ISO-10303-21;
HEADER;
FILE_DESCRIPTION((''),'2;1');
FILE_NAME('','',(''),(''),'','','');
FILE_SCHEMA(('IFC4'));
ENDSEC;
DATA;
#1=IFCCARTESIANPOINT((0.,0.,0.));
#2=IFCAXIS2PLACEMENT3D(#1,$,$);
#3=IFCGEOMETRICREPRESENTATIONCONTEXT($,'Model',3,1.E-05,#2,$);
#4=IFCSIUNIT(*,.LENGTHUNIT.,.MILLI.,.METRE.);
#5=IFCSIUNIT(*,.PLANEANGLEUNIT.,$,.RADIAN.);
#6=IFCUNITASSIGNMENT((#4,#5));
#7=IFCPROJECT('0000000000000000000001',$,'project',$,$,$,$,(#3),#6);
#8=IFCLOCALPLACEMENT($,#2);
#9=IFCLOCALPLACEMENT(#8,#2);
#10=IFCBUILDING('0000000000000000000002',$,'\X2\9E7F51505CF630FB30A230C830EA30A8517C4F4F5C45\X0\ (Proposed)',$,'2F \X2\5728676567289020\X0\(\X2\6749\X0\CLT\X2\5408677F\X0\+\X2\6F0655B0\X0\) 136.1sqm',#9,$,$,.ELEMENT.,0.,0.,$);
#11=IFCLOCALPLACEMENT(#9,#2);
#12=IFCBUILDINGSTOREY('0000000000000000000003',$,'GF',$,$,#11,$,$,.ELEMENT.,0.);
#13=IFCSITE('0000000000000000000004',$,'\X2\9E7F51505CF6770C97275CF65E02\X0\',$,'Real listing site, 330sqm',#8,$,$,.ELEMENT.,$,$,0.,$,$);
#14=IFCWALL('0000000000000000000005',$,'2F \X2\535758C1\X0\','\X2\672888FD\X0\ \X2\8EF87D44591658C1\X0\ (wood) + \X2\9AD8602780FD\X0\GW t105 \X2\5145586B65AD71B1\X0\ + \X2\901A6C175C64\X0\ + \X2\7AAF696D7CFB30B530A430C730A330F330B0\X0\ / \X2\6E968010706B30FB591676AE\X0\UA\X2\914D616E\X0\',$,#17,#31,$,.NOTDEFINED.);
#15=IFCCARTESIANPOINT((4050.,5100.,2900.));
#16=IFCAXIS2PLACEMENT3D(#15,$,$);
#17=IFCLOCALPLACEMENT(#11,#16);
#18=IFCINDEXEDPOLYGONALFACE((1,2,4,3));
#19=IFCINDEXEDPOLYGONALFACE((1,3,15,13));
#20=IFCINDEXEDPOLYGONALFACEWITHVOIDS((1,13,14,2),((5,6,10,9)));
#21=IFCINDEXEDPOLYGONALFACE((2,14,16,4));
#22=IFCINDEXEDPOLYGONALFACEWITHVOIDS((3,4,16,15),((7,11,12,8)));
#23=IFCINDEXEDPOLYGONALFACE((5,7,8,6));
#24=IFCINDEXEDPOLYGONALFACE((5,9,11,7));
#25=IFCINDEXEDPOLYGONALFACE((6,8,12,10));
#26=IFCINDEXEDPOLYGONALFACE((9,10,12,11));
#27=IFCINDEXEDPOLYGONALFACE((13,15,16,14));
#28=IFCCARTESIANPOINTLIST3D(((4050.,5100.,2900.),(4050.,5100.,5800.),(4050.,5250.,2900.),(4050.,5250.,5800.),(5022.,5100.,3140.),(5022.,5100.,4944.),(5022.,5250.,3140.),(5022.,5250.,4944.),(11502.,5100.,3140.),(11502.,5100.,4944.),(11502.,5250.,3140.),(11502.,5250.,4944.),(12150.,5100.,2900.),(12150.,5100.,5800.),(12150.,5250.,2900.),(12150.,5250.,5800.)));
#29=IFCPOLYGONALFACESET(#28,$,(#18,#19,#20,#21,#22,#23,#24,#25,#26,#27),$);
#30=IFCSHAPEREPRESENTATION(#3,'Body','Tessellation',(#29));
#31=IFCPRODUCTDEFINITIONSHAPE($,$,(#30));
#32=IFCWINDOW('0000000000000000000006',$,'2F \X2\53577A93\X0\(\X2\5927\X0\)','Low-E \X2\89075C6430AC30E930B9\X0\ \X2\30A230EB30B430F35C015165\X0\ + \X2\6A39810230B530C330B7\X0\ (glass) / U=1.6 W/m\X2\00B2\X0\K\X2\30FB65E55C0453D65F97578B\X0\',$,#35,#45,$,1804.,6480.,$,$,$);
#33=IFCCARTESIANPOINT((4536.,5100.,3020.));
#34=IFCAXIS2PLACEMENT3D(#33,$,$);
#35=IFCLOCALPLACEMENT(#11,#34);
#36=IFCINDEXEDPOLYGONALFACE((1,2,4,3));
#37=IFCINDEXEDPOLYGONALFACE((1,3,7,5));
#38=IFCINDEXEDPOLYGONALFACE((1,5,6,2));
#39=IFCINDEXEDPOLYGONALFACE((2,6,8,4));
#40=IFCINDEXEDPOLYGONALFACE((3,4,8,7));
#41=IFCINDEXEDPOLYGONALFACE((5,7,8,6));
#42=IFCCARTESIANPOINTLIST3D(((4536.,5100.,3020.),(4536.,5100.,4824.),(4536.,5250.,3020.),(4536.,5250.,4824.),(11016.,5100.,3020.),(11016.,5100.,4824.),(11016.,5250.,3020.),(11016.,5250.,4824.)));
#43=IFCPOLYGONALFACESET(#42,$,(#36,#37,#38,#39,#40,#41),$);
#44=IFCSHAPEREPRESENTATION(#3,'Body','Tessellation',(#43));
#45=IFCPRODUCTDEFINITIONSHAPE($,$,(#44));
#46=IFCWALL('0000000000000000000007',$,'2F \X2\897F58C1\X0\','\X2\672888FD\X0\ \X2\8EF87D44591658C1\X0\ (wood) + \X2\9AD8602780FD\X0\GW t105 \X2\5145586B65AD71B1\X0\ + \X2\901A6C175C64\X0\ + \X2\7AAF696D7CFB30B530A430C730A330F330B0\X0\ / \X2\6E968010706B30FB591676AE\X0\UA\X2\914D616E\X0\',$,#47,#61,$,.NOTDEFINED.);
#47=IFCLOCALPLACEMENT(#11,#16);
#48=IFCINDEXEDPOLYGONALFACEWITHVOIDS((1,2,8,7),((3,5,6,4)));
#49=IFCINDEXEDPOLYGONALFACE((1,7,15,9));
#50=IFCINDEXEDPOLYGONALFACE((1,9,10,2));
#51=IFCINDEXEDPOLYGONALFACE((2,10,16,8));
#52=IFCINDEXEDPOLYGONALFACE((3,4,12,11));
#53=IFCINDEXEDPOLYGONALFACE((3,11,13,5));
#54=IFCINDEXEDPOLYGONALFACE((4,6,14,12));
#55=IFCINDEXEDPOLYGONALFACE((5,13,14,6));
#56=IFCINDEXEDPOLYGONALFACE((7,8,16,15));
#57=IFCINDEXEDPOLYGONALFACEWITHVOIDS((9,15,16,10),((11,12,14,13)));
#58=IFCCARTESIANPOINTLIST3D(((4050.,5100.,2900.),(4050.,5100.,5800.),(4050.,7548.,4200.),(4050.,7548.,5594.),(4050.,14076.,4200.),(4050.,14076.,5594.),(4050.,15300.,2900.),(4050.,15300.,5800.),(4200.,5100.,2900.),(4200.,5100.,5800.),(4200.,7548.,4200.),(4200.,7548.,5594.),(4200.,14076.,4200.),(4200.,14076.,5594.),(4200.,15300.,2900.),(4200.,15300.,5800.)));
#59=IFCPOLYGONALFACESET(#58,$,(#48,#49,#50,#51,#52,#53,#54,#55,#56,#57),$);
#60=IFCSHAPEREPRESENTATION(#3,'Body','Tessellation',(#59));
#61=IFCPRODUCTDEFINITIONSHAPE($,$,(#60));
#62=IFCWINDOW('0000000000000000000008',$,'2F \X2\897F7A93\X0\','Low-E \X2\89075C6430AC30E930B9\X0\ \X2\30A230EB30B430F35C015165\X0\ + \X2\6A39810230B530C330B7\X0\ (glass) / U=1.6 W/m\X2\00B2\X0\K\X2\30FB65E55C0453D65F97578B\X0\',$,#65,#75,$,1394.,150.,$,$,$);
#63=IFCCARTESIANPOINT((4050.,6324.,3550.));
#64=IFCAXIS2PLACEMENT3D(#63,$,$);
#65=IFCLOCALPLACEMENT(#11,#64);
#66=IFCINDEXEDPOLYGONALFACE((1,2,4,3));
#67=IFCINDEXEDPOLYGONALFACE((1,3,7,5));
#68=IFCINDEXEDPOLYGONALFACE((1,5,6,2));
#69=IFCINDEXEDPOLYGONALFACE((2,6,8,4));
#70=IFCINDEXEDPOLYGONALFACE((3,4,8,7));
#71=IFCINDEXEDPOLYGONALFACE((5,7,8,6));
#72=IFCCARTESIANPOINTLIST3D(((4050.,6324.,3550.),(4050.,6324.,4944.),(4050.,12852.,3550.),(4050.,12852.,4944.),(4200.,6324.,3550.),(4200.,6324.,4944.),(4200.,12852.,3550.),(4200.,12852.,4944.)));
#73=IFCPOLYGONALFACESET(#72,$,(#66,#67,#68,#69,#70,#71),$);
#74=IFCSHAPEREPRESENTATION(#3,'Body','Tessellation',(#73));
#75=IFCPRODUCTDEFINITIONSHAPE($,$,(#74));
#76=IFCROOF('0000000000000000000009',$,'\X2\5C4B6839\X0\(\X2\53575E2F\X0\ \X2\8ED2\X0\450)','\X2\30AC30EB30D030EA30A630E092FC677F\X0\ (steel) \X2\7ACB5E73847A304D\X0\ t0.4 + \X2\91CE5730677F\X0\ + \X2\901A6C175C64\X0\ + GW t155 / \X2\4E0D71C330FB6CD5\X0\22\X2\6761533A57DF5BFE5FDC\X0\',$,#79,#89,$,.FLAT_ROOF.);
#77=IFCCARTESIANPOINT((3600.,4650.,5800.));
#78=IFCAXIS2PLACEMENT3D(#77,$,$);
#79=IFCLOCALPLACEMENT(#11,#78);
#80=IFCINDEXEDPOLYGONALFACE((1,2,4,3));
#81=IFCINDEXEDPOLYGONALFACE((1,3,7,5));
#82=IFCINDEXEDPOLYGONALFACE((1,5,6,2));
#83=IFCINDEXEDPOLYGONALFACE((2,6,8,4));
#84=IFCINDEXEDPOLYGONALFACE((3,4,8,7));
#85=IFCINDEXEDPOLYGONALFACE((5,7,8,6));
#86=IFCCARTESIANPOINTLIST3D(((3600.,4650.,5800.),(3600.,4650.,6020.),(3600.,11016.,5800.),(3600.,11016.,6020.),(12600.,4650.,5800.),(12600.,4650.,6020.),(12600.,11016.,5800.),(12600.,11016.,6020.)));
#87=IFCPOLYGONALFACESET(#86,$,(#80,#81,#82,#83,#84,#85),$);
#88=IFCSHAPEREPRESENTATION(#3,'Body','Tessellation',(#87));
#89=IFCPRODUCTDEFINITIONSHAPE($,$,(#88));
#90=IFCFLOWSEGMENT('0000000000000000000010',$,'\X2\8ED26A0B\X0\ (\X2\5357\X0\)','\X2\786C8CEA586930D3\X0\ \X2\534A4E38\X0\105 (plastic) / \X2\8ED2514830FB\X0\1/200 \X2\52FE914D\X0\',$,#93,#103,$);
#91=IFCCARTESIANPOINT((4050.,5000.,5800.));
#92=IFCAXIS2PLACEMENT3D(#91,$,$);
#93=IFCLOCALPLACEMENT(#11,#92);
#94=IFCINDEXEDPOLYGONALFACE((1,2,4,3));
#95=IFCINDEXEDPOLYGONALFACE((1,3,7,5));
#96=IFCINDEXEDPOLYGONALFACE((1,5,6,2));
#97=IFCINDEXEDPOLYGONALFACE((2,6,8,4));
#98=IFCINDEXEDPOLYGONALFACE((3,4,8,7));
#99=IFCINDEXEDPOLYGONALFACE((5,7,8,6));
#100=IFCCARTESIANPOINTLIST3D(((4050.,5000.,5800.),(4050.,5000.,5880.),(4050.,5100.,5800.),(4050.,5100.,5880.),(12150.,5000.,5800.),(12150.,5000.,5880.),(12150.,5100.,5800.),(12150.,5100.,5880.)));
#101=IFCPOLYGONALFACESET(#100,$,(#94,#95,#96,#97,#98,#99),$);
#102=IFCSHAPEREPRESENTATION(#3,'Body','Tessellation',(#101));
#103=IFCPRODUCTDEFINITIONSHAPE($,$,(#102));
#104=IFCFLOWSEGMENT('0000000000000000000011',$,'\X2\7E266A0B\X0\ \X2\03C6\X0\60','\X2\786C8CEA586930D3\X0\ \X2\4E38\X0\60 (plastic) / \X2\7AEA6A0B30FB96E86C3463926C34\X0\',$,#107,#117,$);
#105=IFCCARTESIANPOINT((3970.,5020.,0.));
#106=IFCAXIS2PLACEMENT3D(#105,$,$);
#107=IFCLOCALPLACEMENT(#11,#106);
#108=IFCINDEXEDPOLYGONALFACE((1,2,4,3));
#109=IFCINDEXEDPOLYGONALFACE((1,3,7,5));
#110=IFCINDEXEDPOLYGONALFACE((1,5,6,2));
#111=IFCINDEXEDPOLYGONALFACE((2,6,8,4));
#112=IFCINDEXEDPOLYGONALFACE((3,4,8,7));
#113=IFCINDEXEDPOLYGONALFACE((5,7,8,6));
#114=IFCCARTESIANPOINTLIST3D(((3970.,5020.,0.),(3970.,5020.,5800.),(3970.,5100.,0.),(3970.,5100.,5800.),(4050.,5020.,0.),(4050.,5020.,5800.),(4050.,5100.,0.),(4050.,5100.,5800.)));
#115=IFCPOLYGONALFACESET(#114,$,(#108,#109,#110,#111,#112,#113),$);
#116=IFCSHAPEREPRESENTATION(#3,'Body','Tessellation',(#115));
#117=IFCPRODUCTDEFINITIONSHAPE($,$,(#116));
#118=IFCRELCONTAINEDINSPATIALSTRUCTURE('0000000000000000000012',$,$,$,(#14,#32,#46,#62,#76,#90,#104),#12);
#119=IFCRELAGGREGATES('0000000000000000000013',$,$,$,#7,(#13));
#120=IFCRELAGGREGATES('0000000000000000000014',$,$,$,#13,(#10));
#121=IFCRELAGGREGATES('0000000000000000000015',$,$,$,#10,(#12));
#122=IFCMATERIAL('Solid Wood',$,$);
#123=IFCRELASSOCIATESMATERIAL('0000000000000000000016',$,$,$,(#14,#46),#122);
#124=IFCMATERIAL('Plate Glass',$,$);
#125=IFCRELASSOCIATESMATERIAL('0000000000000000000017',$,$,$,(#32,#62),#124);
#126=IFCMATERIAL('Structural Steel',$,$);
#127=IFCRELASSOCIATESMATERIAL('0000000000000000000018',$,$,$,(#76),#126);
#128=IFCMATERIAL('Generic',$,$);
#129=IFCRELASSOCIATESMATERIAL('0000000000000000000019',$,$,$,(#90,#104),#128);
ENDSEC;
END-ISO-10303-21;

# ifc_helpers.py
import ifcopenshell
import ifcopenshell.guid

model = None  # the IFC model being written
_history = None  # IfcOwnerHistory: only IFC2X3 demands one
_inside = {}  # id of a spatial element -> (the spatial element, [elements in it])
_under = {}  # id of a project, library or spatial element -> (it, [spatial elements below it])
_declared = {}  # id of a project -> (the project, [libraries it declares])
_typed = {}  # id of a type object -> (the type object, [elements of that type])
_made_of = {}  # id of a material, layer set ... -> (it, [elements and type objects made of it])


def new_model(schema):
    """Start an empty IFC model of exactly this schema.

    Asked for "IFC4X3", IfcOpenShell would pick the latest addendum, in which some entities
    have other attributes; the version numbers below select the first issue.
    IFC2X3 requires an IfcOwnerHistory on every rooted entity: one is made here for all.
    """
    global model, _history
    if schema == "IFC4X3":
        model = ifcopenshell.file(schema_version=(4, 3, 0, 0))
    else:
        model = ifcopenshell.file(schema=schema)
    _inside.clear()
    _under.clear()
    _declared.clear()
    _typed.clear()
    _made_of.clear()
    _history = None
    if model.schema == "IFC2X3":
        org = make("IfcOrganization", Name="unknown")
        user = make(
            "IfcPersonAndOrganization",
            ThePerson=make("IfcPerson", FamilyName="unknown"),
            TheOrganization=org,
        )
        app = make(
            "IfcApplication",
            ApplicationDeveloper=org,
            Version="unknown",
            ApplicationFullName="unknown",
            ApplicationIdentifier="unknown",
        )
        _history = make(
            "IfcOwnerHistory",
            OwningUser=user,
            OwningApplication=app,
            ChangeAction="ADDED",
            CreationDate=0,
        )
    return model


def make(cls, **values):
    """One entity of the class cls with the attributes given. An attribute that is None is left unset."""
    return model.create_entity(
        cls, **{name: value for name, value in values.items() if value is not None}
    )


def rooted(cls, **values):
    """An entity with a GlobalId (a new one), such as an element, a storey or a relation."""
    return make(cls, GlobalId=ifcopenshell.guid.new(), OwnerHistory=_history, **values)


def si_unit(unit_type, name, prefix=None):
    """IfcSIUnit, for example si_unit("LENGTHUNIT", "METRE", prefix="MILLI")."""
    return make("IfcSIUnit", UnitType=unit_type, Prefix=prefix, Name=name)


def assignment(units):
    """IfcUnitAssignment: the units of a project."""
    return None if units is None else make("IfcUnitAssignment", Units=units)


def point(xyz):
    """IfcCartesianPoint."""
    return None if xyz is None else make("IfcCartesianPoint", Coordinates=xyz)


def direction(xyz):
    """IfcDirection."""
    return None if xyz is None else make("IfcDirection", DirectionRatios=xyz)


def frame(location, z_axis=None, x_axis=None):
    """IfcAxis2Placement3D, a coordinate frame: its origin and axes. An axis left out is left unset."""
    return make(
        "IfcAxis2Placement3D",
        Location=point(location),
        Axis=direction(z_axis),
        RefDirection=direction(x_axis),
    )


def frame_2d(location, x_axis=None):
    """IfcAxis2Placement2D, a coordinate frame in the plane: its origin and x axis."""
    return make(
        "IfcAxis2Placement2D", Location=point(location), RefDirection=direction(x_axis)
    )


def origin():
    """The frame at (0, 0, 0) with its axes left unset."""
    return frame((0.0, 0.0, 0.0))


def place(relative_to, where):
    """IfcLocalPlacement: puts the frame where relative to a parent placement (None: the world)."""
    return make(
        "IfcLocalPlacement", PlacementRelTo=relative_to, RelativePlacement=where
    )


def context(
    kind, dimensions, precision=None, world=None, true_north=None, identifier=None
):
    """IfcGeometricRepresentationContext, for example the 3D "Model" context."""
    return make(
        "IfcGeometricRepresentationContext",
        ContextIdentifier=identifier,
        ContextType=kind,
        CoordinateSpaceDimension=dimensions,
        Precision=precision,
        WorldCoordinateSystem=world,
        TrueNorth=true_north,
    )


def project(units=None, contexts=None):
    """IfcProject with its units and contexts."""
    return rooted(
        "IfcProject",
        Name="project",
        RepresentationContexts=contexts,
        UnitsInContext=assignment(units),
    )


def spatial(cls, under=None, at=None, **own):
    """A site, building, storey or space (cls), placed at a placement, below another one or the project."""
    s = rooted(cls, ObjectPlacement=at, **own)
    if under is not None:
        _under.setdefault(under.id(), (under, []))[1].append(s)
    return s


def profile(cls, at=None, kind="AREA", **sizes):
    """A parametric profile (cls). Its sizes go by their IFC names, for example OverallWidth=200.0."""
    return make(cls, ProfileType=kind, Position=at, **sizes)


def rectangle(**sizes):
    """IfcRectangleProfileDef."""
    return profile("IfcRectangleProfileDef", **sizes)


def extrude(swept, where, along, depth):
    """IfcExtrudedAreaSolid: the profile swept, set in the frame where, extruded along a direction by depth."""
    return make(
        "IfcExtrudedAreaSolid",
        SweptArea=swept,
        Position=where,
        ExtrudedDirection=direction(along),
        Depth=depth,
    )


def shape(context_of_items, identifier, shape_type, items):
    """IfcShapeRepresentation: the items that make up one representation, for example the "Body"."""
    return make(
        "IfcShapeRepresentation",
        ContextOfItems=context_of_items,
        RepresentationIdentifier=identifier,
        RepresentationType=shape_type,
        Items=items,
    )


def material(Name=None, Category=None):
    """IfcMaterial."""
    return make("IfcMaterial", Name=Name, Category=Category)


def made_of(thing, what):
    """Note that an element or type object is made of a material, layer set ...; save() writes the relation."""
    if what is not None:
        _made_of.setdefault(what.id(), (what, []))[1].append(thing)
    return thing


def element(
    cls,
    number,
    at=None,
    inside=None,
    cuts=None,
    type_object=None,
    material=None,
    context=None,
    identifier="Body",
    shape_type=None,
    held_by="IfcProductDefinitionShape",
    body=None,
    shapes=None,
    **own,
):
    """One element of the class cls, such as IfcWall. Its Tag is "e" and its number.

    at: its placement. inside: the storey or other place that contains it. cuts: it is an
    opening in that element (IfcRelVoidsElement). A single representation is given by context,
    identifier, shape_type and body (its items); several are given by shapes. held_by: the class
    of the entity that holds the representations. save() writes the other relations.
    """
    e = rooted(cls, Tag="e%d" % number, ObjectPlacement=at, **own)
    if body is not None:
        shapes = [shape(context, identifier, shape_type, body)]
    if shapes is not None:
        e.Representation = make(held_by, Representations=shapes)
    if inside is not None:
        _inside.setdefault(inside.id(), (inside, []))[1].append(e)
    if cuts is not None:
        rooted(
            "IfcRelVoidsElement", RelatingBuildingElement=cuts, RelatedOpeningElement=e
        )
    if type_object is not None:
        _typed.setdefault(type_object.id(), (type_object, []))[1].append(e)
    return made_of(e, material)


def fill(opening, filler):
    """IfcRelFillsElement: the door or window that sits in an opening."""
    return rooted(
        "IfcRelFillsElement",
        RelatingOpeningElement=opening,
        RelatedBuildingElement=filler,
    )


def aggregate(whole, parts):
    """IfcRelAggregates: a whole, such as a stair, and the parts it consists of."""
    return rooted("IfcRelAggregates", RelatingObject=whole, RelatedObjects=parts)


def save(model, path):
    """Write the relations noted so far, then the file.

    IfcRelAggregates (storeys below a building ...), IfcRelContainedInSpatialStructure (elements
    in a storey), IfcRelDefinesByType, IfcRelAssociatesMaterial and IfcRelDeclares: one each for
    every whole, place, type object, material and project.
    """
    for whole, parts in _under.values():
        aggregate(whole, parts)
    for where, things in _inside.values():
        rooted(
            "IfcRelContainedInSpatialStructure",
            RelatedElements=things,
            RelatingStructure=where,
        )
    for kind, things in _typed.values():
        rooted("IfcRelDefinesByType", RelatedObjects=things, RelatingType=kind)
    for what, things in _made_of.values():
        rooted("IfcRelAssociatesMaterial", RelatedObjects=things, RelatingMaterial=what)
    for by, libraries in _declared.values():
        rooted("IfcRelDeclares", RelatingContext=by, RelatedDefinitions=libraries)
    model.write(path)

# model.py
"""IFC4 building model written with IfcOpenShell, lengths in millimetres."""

from ifc_helpers import new_model, si_unit, frame, frame_2d, origin, place, context, project, spatial, rectangle, extrude, material, element, fill, save


model = new_model("IFC4")

# Units and contexts
model_context = context("Model", 3, precision=1e-05, world=origin())
ifc_project = project(units=[si_unit("LENGTHUNIT", "METRE", prefix="MILLI"), si_unit("PLANEANGLEUNIT", "RADIAN")], contexts=[model_context])

# Site, building, storey
site_placement = place(None, origin())
site = spatial("IfcSite", under=ifc_project, at=site_placement, Name="鹿児島県霧島市", ObjectType="Real listing site, 330sqm", CompositionType="ELEMENT", RefElevation=0.0)
building_placement = place(site_placement, origin())
building = spatial("IfcBuilding", under=site, at=building_placement, Name="鹿児島・アトリエ兼住居 (Proposed)", ObjectType="2F 在来木造(杉CLT合板+漆喰) 136.1sqm", CompositionType="ELEMENT", ElevationOfRefHeight=0.0, ElevationOfTerrain=0.0)
storey_placement = place(building_placement, origin())
storey = spatial("IfcBuildingStorey", under=building, at=storey_placement, Name="GF", CompositionType="ELEMENT", Elevation=0.0)

# Shared definitions
ifc_material_1 = material(Name="Solid Wood")

# Shared definitions
ifc_material_2 = material(Name="Plate Glass")

# Walls, openings, windows
wall_1_placement = place(storey_placement, frame((4050.0, 5100.0, 2900.0)))
wall_1 = element("IfcWall", 1, at=wall_1_placement, inside=storey, material=ifc_material_1, Name="2F 南壁", Description="木製 軸組外壁 (wood) + 高性能GW t105 充填断熱 + 通気層 + 窯業系サイディング / 準耐火・外皮UA配慮", PredefinedType="NOTDEFINED", context=model_context, shape_type="SweptSolid", body=[
    extrude(rectangle(XDim=8100.0, YDim=150.0, at=frame_2d((4050.0, 75.0))), frame((4050.0, 5100.0, 2900.0)), (0.0, 0.0, 1.0), 2900.0),
])
opening_1_placement = place(storey_placement, frame((4536.0, 5100.0, 3020.0)))
opening_1 = element("IfcOpeningElement", 2, at=opening_1_placement, cuts=wall_1, PredefinedType="NOTDEFINED", context=model_context, shape_type="SweptSolid", body=[
    extrude(rectangle(XDim=6480.0, YDim=150.0, at=frame_2d((3240.0, 75.0))), frame((4536.0, 5100.0, 3020.0)), (0.0, 0.0, 1.0), 1804.0),
])
window_1_placement = place(storey_placement, frame((4536.0, 5100.0, 3020.0)))
window_1 = element("IfcWindow", 3, at=window_1_placement, inside=storey, material=ifc_material_2, Name="2F 南窓(大)", Description="Low-E 複層ガラス アルゴン封入 + 樹脂サッシ (glass) / U=1.6 W/m²K・日射取得型", OverallHeight=1804.0, OverallWidth=6480.0, context=model_context, shape_type="SweptSolid", body=[
    extrude(rectangle(XDim=6480.0, YDim=150.0, at=frame_2d((3240.0, 75.0))), frame((4536.0, 5100.0, 3020.0)), (0.0, 0.0, 1.0), 1804.0),
])
fill(opening_1, window_1)
wall_2_placement = place(storey_placement, frame((4050.0, 5100.0, 2900.0)))
wall_2 = element("IfcWall", 4, at=wall_2_placement, inside=storey, material=ifc_material_1, Name="2F 西壁", Description="木製 軸組外壁 (wood) + 高性能GW t105 充填断熱 + 通気層 + 窯業系サイディング / 準耐火・外皮UA配慮", PredefinedType="NOTDEFINED", context=model_context, shape_type="SweptSolid", body=[
    extrude(rectangle(XDim=150.0, YDim=10200.0, at=frame_2d((75.0, 5100.0))), frame((4050.0, 5100.0, 2900.0)), (0.0, 0.0, 1.0), 2900.0),
])
opening_2_placement = place(storey_placement, frame((4050.0, 6324.0, 3550.0)))
opening_2 = element("IfcOpeningElement", 5, at=opening_2_placement, cuts=wall_2, PredefinedType="NOTDEFINED", context=model_context, shape_type="SweptSolid", body=[
    extrude(rectangle(XDim=150.0, YDim=6528.0, at=frame_2d((75.0, 3264.0))), frame((4050.0, 6324.0, 3550.0)), (0.0, 0.0, 1.0), 1394.0),
])
window_2_placement = place(storey_placement, frame((4050.0, 6324.0, 3550.0)))
window_2 = element("IfcWindow", 6, at=window_2_placement, inside=storey, material=ifc_material_2, Name="2F 西窓", Description="Low-E 複層ガラス アルゴン封入 + 樹脂サッシ (glass) / U=1.6 W/m²K・日射取得型", OverallHeight=1394.0, OverallWidth=150.0, context=model_context, shape_type="SweptSolid", body=[
    extrude(rectangle(XDim=150.0, YDim=6528.0, at=frame_2d((75.0, 3264.0))), frame((4050.0, 6324.0, 3550.0)), (0.0, 0.0, 1.0), 1394.0),
])
fill(opening_2, window_2)

# Roof
ifc_material_3 = material(Name="Structural Steel")
for number, where, name in (
    (7, (3600.0, 4650.0, 5800.0), "屋根(南帯 軒450)"),
):
    element("IfcRoof", number, at=place(storey_placement, frame(where)), inside=storey, material=ifc_material_3, Name=name, Description="ガルバリウム鋼板 (steel) 立平葺き t0.4 + 野地板 + 通気層 + GW t155 / 不燃・法22条区域対応", PredefinedType="FLAT_ROOF", context=model_context, shape_type="SweptSolid", body=[
        extrude(rectangle(XDim=9000.0, YDim=6366.0, at=frame_2d((4500.0, 3183.0))), frame((3600.0, 4650.0, 5800.0)), (0.0, 0.0, 1.0), 220.0),
    ])

# Flow segments
ifc_material_4 = material(Name="Generic")
flow_segment_1_placement = place(storey_placement, frame((4050.0, 5000.0, 5800.0)))
element("IfcFlowSegment", 8, at=flow_segment_1_placement, inside=storey, material=ifc_material_4, Name="軒樋 (南)", Description="硬質塩ビ 半丸105 (plastic) / 軒先・1/200 勾配", context=model_context, shape_type="SweptSolid", body=[
    extrude(rectangle(XDim=8100.0, YDim=100.0, at=frame_2d((4050.0, 50.0))), frame((4050.0, 5000.0, 5800.0)), (0.0, 0.0, 1.0), 80.0),
])
flow_segment_2_placement = place(storey_placement, frame((3970.0, 5020.0, 0.0)))
element("IfcFlowSegment", 9, at=flow_segment_2_placement, inside=storey, material=ifc_material_4, Name="縦樋 φ60", Description="硬質塩ビ 丸60 (plastic) / 竪樋・雨水排水", context=model_context, shape_type="SweptSolid", body=[
    extrude(rectangle(XDim=80.0, YDim=80.0, at=frame_2d((40.0, 40.0))), frame((3970.0, 5020.0, 0.0)), (0.0, 0.0, 1.0), 5800.0),
])

save(model, "model.ifc")
